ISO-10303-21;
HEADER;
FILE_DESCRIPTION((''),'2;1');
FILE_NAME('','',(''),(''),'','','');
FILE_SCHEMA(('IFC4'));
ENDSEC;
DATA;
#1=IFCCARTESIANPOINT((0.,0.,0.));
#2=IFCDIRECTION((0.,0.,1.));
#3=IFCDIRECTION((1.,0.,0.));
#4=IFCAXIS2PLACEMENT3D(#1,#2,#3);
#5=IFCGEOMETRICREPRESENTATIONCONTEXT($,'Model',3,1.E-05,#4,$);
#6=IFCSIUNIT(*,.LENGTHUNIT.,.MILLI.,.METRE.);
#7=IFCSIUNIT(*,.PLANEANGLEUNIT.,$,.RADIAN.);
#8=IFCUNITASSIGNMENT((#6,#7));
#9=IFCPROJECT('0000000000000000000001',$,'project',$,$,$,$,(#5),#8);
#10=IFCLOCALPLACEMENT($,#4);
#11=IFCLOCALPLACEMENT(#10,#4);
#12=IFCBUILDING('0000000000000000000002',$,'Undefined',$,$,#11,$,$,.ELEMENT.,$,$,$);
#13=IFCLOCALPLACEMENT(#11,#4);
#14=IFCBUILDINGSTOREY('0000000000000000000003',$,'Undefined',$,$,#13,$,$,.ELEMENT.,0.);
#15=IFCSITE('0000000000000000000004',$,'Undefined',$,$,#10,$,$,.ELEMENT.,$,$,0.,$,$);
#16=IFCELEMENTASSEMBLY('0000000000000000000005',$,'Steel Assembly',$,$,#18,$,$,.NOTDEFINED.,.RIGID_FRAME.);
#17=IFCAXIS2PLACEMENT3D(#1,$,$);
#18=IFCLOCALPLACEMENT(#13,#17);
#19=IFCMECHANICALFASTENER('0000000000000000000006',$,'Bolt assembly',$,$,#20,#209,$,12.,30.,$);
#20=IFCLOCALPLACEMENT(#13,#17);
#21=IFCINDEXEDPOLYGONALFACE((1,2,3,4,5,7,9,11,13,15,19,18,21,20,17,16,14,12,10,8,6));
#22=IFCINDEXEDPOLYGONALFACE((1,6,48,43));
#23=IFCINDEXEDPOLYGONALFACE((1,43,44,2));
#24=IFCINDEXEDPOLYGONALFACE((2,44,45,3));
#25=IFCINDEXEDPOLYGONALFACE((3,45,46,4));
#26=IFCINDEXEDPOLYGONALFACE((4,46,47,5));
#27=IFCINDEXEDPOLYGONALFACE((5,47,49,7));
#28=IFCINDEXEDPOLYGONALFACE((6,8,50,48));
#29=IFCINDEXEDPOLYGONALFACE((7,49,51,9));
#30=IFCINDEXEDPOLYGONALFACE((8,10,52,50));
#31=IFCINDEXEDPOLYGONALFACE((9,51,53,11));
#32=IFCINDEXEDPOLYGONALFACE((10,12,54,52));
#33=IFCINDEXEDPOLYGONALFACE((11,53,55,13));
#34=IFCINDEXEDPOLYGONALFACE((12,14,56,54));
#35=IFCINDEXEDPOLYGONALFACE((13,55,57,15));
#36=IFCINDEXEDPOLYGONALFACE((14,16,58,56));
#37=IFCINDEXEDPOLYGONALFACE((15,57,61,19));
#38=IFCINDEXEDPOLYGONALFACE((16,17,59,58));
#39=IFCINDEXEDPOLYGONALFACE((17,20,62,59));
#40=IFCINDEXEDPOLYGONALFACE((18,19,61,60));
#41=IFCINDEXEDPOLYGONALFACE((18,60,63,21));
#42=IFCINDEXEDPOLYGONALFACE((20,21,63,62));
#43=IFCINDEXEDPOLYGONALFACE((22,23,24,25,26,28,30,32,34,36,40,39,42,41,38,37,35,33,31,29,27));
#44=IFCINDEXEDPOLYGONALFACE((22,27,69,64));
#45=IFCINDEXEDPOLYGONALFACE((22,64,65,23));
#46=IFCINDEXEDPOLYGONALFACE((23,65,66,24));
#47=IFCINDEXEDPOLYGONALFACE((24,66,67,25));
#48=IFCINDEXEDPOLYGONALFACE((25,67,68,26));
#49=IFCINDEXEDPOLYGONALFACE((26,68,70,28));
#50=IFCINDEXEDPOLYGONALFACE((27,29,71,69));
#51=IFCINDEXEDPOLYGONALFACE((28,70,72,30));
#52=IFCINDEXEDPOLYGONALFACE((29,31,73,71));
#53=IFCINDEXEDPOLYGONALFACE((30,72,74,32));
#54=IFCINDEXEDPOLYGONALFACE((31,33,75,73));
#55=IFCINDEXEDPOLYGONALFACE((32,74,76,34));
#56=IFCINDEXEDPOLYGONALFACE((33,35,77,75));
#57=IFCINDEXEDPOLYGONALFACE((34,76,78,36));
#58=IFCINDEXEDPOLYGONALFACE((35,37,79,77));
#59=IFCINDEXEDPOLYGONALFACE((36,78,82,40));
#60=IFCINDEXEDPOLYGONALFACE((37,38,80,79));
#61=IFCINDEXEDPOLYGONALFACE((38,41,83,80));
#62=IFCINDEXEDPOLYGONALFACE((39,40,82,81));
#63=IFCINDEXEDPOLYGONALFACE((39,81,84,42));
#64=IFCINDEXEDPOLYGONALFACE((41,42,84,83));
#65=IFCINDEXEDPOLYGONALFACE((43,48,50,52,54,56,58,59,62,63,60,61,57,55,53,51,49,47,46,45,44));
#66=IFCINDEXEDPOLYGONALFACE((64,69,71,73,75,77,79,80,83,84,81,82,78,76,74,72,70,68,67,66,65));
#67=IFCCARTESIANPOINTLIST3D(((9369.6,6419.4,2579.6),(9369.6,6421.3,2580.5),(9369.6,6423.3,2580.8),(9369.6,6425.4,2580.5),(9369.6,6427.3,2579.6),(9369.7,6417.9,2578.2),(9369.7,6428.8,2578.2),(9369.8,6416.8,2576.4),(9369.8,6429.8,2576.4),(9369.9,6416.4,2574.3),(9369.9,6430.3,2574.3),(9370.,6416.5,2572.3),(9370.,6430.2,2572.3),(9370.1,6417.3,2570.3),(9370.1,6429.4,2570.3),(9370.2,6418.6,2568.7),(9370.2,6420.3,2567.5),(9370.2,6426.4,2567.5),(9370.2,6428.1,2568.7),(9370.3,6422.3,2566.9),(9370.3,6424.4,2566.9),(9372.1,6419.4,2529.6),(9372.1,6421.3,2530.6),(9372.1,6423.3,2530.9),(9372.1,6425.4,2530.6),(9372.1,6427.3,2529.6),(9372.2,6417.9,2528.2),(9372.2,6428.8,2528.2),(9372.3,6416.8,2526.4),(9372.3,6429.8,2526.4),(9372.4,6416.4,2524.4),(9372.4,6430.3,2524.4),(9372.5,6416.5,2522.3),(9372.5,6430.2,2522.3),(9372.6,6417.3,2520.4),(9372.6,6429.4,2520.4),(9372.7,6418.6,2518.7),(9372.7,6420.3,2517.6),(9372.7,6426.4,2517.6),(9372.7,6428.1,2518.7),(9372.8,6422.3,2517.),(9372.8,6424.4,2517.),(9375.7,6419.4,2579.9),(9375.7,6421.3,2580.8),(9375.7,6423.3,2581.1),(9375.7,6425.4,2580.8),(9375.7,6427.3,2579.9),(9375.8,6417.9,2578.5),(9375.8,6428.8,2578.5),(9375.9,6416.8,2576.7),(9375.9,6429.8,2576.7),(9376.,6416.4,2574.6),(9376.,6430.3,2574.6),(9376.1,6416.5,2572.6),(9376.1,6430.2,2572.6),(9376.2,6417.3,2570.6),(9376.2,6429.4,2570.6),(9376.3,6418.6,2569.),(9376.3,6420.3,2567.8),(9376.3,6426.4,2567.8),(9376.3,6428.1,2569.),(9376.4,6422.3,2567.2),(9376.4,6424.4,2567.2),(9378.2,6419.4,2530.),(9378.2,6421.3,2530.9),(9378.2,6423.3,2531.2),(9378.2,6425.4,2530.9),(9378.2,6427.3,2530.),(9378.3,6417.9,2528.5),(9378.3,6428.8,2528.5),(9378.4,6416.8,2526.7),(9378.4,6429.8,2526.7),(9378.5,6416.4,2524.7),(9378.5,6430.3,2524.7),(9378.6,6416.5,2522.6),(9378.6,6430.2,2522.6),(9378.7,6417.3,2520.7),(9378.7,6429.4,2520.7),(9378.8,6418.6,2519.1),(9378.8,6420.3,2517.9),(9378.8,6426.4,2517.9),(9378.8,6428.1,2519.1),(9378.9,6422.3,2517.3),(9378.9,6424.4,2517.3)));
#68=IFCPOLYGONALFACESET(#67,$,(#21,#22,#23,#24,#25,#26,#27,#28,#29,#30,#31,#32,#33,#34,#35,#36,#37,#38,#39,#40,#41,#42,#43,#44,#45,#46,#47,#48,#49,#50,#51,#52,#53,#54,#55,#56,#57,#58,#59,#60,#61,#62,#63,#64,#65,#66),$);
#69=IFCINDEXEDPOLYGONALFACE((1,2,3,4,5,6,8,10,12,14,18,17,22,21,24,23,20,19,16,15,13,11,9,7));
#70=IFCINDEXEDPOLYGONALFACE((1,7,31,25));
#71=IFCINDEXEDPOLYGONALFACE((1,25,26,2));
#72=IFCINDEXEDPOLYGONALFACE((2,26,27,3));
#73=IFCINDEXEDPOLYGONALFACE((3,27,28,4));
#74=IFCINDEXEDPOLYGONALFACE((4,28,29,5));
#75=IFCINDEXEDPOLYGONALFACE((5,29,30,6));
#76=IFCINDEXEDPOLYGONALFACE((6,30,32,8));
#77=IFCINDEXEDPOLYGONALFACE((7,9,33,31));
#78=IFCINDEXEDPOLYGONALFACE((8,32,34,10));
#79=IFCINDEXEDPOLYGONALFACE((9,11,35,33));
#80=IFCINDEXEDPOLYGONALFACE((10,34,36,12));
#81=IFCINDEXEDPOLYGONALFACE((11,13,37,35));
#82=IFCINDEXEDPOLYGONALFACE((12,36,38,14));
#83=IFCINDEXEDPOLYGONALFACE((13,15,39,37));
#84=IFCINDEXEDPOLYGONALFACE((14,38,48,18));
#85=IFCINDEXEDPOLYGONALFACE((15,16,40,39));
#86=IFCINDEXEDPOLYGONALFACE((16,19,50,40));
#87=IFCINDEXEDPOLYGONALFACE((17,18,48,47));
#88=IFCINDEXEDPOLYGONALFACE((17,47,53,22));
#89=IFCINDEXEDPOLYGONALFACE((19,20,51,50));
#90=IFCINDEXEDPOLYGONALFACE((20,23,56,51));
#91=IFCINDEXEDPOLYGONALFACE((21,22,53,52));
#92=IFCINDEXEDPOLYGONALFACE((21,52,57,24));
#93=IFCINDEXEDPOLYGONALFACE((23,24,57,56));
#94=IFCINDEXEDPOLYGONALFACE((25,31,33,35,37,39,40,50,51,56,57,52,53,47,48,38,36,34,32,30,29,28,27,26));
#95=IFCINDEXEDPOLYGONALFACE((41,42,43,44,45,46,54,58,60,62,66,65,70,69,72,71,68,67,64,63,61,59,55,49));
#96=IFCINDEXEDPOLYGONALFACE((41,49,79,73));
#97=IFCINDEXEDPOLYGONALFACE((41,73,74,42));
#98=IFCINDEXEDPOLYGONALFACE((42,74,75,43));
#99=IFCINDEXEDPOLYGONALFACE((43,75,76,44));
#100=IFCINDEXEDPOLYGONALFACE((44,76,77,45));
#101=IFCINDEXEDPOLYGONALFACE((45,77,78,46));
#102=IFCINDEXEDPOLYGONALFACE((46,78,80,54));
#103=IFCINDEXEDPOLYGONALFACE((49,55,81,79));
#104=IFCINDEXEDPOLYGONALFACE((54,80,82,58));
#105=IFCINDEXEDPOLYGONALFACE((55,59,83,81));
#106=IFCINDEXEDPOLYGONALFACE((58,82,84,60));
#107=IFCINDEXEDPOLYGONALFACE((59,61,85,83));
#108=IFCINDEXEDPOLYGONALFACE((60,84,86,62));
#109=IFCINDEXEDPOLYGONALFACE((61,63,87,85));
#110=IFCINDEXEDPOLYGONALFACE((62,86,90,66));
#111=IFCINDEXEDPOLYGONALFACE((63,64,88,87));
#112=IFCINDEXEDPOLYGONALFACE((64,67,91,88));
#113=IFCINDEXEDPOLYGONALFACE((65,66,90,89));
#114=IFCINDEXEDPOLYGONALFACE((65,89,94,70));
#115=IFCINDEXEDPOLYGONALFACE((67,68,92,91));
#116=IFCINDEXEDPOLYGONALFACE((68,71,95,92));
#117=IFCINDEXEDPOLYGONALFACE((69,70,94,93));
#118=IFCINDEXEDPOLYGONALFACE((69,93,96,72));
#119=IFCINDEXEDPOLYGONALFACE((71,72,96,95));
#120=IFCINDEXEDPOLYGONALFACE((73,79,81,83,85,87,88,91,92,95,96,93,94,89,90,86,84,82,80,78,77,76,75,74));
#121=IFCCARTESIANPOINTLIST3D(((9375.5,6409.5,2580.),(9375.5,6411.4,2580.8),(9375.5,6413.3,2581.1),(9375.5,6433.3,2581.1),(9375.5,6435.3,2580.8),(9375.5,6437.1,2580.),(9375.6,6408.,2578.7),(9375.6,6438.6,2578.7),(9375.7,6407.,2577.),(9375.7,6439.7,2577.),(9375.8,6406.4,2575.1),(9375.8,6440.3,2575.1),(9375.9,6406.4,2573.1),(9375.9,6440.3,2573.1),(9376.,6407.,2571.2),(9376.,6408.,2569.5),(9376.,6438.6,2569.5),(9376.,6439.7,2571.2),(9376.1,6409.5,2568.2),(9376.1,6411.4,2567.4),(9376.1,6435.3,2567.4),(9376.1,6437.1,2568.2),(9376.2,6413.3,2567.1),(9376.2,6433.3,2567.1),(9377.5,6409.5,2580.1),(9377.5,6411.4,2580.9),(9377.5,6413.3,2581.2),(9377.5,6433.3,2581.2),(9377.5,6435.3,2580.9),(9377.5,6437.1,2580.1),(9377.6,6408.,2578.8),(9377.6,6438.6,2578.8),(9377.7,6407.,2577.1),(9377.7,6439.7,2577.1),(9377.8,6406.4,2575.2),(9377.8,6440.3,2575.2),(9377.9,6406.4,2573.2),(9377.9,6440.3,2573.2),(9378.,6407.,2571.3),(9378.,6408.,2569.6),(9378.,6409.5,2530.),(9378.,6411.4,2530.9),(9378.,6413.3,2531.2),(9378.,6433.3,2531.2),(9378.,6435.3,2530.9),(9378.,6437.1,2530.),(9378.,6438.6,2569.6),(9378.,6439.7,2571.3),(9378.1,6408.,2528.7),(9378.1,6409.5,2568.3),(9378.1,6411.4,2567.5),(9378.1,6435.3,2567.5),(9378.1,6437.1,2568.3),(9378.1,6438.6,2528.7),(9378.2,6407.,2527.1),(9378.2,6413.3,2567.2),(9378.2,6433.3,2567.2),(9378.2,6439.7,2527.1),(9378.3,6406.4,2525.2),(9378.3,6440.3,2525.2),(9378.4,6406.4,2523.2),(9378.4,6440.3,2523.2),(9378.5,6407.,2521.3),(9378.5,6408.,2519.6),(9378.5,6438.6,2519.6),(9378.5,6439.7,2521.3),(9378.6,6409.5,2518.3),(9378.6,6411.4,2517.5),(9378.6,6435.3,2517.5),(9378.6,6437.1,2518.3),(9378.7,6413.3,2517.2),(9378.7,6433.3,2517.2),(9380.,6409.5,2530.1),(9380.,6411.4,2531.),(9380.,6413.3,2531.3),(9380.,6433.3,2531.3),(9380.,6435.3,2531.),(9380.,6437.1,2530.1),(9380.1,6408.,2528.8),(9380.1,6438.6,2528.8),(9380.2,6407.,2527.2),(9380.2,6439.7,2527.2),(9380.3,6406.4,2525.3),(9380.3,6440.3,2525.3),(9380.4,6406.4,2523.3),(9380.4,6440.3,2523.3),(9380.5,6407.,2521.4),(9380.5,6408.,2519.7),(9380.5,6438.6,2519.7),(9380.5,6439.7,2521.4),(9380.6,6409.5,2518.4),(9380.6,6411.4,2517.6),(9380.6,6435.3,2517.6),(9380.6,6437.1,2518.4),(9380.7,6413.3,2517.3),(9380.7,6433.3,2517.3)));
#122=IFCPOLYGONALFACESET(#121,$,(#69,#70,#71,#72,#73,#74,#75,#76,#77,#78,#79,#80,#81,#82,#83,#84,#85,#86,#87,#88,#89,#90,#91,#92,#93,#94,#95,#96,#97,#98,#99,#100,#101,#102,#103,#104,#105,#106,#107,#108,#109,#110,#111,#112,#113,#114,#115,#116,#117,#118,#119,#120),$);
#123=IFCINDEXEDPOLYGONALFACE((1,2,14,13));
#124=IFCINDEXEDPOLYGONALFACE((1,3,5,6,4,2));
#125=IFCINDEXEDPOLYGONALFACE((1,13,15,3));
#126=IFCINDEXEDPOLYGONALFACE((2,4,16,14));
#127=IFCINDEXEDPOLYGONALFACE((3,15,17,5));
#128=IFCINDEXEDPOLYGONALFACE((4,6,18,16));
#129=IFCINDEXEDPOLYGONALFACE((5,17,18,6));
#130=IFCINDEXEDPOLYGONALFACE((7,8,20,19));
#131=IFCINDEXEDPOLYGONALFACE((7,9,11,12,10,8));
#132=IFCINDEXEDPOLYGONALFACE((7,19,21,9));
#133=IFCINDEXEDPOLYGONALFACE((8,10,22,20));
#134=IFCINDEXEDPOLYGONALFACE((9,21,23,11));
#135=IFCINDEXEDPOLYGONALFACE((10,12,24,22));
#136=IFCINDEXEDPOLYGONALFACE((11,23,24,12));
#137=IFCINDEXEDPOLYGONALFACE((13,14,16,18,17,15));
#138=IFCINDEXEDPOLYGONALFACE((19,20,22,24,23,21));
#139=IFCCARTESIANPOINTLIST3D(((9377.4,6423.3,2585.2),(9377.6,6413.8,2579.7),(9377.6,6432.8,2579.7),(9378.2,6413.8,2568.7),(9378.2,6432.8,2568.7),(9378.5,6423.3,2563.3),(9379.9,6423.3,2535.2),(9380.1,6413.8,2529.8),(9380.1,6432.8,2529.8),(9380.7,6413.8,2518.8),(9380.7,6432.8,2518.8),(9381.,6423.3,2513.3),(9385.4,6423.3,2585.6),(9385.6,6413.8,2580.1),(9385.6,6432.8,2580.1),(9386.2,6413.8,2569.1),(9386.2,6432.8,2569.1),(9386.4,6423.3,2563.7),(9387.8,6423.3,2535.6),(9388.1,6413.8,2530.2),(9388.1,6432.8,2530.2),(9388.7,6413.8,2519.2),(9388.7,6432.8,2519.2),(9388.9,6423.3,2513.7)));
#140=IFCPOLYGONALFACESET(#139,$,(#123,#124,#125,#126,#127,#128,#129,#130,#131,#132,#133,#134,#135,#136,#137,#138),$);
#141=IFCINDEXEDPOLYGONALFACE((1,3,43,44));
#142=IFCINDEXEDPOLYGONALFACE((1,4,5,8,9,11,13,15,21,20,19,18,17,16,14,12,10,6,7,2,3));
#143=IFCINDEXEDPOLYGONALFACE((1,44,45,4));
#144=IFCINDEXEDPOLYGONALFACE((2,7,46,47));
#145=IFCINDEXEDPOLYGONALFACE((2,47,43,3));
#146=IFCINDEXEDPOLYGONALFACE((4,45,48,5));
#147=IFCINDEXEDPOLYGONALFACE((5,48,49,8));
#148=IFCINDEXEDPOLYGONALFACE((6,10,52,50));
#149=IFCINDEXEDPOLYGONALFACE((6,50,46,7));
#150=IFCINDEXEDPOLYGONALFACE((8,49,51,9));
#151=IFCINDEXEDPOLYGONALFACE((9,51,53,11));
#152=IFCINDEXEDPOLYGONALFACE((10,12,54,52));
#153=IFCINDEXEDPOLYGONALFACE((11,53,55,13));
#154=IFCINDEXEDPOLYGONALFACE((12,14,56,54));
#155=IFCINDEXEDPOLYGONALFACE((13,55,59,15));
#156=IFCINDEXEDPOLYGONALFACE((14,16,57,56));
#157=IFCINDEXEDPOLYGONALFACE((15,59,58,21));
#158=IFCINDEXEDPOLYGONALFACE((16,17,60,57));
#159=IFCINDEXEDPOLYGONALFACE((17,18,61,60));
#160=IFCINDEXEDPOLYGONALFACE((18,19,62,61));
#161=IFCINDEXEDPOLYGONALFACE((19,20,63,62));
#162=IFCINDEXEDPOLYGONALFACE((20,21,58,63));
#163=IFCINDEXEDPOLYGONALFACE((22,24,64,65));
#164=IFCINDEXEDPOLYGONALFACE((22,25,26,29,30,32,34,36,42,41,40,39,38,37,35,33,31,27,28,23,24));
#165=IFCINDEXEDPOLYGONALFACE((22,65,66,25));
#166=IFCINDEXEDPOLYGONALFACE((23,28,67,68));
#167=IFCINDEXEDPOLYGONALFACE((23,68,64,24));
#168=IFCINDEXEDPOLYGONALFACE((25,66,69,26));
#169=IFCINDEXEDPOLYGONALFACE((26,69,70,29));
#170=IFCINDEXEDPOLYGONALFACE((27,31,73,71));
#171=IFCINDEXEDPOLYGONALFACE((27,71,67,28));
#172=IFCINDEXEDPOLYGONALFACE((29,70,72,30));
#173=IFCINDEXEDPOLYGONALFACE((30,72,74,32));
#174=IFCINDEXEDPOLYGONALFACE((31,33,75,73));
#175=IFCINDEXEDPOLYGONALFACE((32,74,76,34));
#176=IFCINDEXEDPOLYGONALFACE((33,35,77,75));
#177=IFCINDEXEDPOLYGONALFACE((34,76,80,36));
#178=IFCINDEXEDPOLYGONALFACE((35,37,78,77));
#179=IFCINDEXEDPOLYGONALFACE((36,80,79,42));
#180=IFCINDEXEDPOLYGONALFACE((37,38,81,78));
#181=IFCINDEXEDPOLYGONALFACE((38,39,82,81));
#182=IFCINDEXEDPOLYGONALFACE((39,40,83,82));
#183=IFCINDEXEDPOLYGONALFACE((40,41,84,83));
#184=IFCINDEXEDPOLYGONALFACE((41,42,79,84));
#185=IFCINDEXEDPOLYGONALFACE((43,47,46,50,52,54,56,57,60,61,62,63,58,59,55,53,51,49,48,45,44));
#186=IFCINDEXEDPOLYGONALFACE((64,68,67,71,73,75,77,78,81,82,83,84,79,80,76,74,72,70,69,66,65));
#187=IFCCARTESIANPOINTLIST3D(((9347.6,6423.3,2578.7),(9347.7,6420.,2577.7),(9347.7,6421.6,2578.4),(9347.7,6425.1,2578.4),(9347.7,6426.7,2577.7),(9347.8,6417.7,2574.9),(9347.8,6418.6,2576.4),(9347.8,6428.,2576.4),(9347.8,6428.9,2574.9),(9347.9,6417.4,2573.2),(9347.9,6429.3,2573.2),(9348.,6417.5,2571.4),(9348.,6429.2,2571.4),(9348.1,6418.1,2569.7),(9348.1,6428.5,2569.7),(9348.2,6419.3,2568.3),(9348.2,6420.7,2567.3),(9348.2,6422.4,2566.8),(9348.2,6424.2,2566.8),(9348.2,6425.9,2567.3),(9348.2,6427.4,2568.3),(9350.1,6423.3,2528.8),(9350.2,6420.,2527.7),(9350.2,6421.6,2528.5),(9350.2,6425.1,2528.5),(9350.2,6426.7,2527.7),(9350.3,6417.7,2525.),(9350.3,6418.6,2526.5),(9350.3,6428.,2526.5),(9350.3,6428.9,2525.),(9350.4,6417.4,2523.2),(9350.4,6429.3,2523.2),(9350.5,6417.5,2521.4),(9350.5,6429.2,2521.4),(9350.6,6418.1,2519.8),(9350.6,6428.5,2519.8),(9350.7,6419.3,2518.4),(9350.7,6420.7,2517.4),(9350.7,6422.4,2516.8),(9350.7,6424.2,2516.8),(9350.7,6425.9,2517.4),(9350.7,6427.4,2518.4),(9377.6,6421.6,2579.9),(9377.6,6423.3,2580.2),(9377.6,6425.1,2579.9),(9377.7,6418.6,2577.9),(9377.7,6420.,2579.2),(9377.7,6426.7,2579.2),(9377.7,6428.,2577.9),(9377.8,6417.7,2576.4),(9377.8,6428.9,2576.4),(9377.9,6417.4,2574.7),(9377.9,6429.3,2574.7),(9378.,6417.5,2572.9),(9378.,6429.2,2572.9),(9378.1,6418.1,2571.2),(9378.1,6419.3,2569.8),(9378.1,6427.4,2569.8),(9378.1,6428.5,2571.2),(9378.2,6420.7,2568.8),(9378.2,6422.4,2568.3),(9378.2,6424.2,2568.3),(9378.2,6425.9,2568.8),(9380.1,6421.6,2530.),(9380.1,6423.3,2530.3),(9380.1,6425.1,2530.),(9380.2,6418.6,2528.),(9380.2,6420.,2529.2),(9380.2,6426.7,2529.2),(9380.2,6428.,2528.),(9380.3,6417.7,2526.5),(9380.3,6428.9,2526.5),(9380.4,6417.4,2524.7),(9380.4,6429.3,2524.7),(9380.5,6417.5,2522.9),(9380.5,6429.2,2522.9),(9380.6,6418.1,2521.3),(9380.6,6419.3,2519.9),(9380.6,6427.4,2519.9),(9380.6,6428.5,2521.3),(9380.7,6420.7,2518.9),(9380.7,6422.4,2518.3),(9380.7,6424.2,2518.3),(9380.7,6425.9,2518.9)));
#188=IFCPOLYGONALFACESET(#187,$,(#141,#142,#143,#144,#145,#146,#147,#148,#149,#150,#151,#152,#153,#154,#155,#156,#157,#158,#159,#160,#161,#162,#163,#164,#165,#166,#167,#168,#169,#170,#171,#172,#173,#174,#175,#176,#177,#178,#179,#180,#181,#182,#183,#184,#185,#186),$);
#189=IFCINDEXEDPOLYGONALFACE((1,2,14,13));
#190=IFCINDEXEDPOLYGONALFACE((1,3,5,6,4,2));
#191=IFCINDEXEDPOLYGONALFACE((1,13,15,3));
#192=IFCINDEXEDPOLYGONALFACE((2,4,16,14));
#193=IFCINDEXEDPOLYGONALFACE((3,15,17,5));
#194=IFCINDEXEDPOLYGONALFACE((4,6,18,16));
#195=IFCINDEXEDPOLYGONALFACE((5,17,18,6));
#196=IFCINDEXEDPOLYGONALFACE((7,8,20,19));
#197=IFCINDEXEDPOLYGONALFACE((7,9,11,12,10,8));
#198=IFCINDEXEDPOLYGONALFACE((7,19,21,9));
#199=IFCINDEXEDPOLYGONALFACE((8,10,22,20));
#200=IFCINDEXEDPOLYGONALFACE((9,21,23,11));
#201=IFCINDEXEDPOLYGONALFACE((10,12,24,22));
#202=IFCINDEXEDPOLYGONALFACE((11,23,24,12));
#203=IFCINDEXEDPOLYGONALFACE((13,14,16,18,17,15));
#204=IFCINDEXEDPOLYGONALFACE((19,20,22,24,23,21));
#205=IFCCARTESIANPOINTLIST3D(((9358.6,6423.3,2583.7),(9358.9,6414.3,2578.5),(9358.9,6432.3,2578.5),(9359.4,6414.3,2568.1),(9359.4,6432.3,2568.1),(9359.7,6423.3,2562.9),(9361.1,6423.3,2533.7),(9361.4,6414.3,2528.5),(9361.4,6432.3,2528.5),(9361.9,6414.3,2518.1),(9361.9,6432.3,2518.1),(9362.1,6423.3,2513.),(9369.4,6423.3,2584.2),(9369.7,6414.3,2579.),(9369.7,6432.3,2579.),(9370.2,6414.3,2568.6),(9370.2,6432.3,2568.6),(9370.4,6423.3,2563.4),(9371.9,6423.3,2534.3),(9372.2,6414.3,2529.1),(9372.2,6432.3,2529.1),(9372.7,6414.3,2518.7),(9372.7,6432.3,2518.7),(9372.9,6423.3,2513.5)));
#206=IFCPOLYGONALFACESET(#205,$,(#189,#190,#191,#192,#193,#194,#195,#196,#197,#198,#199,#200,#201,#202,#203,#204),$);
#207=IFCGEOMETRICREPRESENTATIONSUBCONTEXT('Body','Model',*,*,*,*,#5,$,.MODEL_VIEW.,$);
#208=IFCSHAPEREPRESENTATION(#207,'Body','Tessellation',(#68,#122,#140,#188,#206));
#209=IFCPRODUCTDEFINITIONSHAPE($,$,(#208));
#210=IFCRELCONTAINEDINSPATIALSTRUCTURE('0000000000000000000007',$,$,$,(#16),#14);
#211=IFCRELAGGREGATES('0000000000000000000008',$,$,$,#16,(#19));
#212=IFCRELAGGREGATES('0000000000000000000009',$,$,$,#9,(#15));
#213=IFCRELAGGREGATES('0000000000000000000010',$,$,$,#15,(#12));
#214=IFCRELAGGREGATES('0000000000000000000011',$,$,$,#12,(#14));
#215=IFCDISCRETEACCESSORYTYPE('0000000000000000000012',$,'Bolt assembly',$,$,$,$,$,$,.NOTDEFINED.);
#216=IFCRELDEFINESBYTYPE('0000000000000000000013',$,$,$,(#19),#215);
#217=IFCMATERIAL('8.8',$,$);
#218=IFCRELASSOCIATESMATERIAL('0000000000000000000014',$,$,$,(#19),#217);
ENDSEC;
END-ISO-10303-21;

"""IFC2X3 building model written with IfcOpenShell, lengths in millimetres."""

from ifc_helpers import new_model, si_unit, frame, frame_2d, origin_with_axes, origin_2d_with_axis, place, context, subcontext, project, spatial, polyline, circle_curve, parameter, trimmed, segment, composite_curve, circle, outline, extrude, source, transform, mapped, material, type_object, element, aggregate, save


model = new_model("IFC2X3")

# Units and contexts
model_context = context("Model", 3, precision=1e-05, world=origin_with_axes())
body_context = subcontext(model_context, "Body", "Model", "MODEL_VIEW")
ifc_project = project(units=[si_unit("LENGTHUNIT", "METRE", prefix="MILLI"), si_unit("PLANEANGLEUNIT", "RADIAN")], contexts=[model_context])

# Site, building, storey
site_placement = place(None, origin_with_axes())
site = spatial("IfcSite", under=ifc_project, at=site_placement, Name="Undefined", CompositionType="ELEMENT", RefElevation=0.0)
building_placement = place(site_placement, origin_with_axes())
building = spatial("IfcBuilding", under=site, at=building_placement, Name="Undefined", CompositionType="ELEMENT")
storey_placement = place(building_placement, origin_with_axes())
storey = spatial("IfcBuildingStorey", under=building, at=storey_placement, Name="Undefined", CompositionType="ELEMENT", Elevation=0.0)

# Element assembly
assembly_1_placement = place(storey_placement, origin_with_axes())
assembly_1 = element("IfcElementAssembly", 1, at=assembly_1_placement, inside=storey, Name="Steel Assembly", AssemblyPlace="NOTDEFINED", PredefinedType="RIGID_FRAME")

# Mechanical fastener
discrete_accessory_type_1 = type_object("IfcDiscreteAccessoryType", Name="Bolt assembly")
ifc_material_1 = material(Name="8.8")
shared_shape_1 = source(origin_with_axes(), body_context, "Body", "SweptSolid", [
    extrude(circle(Radius=7.0, at=origin_2d_with_axis()), frame((0.0, -3.1, 0.0), z_axis=(0.0, 1.0, 0.0), x_axis=(1.0, 0.0, 0.0)), (0.0, 0.0, 1.0), 6.1),
    extrude(outline(composite_curve([segment(polyline([(7.0, 10.0), (7.0, -10.0)]), True, "CONTINUOUS"), segment(trimmed(circle_curve(frame_2d((0.0, -10.0), x_axis=(1.0, 0.0)), 7.0), [parameter(0.0)], [parameter(3.1416)], False, "PARAMETER"), True, "CONTINUOUS"), segment(polyline([(-7.0, -10.0), (-7.0, 10.0)]), True, "CONTINUOUS"), segment(trimmed(circle_curve(frame_2d((0.0, 10.0), x_axis=(-1.0, 0.0)), 7.0), [parameter(0.0)], [parameter(3.1416)], False, "PARAMETER"), True, "DISCONTINUOUS")], self_intersect=False)), frame((0.0, -4.9, 0.0), z_axis=(0.0, 1.0, 0.0), x_axis=(1.0, 0.0, 0.0)), (0.0, 0.0, 1.0), 2.0),
    extrude(outline(polyline([(11.0, 0.0), (5.5, 9.5), (-5.5, 9.5), (-11.0, 0.0), (-5.5, -9.5), (5.5, -9.5), (11.0, 0.0)])), frame((0.0, -13.0, 0.0), z_axis=(0.0, 1.0, 0.0), x_axis=(1.0, 0.0, 0.0)), (0.0, 0.0, 1.0), 8.0),
    extrude(circle(Radius=6.0, at=origin_2d_with_axis()), frame((0.0, -5.0, 0.0), z_axis=(0.0, 1.0, 0.0), x_axis=(1.0, 0.0, 0.0)), (0.0, 0.0, 1.0), 30.0),
    extrude(outline(polyline([(10.4, 0.0), (5.2, 9.0), (-5.2, 9.0), (-10.4, 0.0), (-5.2, -9.0), (5.2, -9.0), (10.4, 0.0)])), frame((0.0, 3.0, 0.0), z_axis=(0.0, 1.0, 0.0), x_axis=(1.0, 0.0, 0.0)), (0.0, 0.0, 1.0), 10.8),
])
mechanical_fastener_1_placement = place(assembly_1_placement, frame((9376.7, 6468.3, 2499.1), z_axis=(0.0, -1.0, 0.0), x_axis=(-0.049938, 0.0, 0.998752)))
mechanical_fastener_1 = element("IfcMechanicalFastener", 2, at=mechanical_fastener_1_placement, type_object=discrete_accessory_type_1, material=ifc_material_1, Name="Bolt assembly", NominalDiameter=12.0, NominalLength=30.0, context=body_context, shape_type="MappedRepresentation", body=[
    mapped(shared_shape_1, transform((25.0, 0.0, 45.0))),
    mapped(shared_shape_1, transform((75.0, 0.0, 45.0))),
])
aggregate(assembly_1, [mechanical_fastener_1])

save(model, "model.ifc")
